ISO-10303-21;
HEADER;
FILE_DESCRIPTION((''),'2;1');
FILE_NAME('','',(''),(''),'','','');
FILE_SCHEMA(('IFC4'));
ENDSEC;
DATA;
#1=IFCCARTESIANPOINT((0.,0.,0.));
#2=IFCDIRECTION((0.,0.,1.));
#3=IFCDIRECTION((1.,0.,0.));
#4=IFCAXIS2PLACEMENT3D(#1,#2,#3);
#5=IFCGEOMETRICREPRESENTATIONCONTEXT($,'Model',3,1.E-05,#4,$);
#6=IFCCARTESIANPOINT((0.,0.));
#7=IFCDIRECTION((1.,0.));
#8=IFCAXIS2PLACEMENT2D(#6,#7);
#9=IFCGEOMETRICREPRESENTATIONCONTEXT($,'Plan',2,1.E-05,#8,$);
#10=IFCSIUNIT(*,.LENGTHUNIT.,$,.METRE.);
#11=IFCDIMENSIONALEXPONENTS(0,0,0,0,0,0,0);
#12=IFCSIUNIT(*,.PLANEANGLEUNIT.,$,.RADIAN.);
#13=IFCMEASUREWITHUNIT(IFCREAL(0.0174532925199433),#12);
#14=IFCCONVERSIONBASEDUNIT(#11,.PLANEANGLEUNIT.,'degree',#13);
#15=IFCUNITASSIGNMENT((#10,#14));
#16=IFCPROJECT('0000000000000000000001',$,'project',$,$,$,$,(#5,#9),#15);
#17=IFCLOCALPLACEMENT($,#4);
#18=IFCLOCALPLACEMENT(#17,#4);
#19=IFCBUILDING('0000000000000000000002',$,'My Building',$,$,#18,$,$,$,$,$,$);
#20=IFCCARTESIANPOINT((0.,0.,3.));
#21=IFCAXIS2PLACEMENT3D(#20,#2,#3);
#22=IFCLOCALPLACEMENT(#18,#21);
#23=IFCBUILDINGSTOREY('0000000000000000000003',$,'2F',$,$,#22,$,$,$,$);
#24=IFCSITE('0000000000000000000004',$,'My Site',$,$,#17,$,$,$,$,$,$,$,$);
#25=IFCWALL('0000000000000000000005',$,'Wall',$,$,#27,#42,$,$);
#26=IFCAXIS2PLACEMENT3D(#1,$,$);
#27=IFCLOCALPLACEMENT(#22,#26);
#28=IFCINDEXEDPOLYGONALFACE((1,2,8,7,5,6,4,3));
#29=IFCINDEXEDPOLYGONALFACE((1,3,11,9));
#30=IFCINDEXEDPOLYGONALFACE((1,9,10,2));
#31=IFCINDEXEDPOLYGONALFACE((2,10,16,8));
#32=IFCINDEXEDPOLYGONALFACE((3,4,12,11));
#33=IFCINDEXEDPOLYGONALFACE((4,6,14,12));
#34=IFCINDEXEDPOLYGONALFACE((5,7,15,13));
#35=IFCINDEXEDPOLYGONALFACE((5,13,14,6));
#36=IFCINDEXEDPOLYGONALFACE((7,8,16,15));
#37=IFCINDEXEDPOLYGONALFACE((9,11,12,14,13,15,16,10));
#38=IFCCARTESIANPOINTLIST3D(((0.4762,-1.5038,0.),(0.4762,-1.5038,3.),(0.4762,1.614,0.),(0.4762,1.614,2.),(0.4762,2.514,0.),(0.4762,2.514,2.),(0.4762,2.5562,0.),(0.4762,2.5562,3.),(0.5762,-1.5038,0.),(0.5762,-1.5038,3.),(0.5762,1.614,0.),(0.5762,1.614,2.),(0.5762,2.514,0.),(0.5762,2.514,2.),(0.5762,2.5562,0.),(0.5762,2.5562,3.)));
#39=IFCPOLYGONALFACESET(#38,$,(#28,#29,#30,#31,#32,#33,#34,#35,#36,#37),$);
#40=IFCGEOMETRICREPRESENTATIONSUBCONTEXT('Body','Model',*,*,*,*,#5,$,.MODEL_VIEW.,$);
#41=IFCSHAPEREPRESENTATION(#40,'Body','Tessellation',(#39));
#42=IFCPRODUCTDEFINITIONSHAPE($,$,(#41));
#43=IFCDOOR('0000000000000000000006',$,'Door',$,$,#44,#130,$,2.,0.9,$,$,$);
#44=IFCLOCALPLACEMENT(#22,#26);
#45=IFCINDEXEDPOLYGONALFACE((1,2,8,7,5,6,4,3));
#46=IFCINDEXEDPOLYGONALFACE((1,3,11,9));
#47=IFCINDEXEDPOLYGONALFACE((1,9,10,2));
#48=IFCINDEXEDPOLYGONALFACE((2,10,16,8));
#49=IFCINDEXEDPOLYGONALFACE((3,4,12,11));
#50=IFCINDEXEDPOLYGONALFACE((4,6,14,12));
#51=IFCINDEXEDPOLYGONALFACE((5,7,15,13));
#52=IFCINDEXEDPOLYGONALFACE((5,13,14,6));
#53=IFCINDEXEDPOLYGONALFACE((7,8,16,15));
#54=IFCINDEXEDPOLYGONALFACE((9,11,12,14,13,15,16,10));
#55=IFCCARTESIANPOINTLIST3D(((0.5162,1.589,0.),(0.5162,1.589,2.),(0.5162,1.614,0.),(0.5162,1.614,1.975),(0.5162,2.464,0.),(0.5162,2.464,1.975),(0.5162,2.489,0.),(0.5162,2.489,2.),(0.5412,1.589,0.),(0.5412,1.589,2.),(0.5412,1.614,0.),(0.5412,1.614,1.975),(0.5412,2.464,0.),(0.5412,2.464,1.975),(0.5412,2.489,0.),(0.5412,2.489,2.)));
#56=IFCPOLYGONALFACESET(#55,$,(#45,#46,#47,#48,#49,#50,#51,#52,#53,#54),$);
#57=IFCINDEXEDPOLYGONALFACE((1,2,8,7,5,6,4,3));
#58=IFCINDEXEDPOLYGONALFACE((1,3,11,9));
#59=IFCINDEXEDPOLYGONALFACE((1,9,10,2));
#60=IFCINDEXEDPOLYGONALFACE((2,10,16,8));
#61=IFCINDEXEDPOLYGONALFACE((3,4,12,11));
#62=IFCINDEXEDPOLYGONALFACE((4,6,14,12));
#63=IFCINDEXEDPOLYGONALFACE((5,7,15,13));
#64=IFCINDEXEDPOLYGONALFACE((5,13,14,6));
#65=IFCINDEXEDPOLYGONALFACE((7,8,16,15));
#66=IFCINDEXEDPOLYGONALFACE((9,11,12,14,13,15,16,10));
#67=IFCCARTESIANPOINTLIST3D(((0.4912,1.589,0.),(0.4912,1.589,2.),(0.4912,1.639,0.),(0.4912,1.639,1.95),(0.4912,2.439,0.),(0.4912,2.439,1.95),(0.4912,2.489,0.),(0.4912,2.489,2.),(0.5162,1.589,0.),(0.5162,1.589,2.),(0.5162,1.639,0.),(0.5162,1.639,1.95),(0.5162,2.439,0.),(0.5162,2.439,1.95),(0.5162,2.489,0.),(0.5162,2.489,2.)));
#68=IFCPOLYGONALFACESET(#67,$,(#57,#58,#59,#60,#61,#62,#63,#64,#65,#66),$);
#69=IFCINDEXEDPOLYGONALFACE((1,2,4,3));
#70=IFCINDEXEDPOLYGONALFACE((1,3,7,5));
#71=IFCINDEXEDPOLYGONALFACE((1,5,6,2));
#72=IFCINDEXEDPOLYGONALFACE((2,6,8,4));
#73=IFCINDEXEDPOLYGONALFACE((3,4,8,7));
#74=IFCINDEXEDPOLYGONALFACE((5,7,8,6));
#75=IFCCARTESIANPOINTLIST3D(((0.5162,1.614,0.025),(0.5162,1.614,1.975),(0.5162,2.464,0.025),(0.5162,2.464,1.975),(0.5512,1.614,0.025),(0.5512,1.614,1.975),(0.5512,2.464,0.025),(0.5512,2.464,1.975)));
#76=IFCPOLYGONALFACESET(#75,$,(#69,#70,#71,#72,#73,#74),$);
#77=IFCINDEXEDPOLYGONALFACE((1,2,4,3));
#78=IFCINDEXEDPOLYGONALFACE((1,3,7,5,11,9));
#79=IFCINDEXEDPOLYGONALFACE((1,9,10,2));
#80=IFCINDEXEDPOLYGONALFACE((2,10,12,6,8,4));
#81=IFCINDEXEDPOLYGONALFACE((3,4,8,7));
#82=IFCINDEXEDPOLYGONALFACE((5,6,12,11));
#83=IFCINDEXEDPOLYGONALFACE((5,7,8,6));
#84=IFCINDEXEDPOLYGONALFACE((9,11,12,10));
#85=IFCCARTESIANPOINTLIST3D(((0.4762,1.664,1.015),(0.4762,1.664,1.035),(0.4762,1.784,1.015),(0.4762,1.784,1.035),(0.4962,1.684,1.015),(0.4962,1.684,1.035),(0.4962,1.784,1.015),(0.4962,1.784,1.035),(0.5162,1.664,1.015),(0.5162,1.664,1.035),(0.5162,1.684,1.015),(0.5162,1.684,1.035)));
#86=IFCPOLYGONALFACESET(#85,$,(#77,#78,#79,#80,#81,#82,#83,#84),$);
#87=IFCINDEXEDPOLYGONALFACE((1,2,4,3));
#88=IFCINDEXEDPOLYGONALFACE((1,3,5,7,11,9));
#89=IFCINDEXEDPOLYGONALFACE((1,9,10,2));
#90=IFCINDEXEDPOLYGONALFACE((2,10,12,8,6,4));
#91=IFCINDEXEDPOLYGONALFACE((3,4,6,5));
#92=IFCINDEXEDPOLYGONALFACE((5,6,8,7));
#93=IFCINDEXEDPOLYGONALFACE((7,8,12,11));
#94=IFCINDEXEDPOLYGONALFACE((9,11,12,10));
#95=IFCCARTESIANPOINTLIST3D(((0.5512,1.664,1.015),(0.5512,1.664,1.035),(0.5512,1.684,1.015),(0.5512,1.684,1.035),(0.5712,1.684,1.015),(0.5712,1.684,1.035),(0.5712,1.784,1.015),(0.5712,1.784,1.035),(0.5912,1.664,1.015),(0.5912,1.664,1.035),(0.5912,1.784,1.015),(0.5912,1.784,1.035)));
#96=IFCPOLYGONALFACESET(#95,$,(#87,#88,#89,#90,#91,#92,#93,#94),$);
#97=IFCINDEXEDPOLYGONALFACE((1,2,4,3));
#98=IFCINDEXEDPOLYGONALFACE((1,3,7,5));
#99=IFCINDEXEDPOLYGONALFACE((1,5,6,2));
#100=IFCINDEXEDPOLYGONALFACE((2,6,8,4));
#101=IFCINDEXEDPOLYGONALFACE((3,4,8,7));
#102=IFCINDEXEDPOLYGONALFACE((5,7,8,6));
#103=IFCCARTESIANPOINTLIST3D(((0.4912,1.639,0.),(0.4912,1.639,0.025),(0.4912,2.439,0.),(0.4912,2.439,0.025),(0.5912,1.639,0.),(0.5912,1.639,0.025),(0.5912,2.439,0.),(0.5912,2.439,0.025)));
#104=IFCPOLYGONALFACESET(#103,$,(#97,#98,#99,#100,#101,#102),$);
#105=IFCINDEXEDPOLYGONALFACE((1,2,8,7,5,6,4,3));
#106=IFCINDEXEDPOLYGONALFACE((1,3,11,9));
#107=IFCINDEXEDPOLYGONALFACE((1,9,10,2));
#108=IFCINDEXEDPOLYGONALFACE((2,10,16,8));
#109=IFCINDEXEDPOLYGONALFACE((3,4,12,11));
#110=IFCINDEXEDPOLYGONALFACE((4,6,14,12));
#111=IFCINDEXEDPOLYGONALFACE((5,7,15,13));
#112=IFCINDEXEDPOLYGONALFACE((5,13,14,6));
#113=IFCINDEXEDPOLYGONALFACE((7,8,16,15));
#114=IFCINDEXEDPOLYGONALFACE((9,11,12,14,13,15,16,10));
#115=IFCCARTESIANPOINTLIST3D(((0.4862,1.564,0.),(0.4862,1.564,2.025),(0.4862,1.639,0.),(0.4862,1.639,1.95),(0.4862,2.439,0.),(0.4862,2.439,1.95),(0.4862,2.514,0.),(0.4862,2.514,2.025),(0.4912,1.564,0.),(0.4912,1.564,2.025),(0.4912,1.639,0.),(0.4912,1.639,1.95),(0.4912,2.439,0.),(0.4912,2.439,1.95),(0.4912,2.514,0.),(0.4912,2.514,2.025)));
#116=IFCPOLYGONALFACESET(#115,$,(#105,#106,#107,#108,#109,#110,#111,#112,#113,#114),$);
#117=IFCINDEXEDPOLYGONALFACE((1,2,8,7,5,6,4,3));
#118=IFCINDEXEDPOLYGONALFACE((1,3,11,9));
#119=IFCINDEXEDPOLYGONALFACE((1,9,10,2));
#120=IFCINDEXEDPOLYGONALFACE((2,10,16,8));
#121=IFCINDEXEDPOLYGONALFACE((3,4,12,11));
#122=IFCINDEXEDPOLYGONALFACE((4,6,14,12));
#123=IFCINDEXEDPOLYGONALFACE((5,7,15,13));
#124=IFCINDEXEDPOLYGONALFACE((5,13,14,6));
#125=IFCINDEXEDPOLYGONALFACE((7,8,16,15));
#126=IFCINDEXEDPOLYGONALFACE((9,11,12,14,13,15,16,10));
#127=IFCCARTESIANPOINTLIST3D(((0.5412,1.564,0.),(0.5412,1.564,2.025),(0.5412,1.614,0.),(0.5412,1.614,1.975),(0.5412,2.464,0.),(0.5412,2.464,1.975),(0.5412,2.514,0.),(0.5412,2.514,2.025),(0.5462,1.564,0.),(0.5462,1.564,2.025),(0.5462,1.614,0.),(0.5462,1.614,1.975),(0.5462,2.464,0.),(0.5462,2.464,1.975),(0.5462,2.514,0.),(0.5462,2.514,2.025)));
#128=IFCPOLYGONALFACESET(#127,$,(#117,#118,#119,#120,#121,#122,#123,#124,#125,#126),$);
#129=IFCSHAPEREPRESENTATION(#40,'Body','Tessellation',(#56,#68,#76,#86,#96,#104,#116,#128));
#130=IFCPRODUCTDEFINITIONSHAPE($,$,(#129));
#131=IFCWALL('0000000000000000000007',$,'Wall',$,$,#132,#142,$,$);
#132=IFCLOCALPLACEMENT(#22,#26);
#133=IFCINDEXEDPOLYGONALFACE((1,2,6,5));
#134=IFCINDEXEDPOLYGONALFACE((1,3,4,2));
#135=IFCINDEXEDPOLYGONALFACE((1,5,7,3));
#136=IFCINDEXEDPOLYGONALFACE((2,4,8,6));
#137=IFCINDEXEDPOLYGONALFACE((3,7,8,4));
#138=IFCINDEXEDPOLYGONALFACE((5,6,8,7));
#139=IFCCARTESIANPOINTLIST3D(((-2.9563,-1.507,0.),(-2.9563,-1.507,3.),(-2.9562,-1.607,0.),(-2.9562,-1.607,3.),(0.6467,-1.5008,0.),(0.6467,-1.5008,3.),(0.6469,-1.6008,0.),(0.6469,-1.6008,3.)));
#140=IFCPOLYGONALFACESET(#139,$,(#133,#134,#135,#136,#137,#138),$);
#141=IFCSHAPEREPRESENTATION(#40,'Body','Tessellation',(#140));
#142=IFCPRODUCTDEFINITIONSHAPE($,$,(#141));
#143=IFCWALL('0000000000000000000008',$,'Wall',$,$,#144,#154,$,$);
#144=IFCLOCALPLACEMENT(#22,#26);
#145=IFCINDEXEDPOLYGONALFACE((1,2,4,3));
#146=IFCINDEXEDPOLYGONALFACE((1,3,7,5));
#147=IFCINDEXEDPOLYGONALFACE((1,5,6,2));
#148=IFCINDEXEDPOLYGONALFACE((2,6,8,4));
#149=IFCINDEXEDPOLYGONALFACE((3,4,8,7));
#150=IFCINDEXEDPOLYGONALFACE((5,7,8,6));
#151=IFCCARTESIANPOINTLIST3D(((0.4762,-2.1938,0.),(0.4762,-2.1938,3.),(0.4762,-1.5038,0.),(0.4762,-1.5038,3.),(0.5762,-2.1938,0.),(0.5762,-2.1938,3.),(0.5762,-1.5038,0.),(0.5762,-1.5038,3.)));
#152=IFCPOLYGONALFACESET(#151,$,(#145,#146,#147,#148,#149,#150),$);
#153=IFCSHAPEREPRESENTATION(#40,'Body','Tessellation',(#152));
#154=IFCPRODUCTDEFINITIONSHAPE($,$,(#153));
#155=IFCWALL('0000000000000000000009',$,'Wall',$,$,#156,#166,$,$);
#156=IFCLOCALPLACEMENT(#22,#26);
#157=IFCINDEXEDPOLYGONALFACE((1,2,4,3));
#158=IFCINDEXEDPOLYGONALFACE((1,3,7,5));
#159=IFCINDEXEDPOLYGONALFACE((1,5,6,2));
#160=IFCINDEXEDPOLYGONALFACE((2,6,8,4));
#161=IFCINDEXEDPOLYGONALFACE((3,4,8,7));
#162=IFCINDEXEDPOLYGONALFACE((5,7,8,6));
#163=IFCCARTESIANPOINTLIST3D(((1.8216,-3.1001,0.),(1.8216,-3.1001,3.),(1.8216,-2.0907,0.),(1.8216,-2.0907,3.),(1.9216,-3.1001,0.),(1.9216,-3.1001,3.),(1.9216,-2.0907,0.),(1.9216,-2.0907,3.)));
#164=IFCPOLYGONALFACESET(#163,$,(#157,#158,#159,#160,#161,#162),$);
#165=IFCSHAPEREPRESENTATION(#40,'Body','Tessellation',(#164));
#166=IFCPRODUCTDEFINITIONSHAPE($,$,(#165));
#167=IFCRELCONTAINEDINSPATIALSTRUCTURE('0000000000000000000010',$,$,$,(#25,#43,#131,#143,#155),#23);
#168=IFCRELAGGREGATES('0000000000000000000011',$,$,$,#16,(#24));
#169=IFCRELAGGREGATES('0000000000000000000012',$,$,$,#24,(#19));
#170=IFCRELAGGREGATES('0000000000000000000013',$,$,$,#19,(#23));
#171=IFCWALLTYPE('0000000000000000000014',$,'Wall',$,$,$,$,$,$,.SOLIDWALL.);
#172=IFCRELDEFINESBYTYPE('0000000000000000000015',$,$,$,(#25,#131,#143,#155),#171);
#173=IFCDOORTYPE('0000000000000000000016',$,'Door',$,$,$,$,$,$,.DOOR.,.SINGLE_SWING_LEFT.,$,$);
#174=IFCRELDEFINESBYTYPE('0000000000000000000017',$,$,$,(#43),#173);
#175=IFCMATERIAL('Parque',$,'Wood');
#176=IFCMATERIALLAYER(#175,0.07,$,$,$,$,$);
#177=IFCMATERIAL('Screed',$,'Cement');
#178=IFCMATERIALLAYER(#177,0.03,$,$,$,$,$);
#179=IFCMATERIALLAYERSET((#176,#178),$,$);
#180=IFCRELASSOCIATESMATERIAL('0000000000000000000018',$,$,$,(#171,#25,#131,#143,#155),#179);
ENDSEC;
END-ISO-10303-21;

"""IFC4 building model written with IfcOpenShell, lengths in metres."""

from ifc_helpers import new_model, entity, si_unit, converted_unit, frame, origin_with_axes, origin_2d_with_axis, place, context, subcontext, project, spatial, line, indexed_curve, outline, extrude, shape, source, transform, mapped, material, layer, layer_set, layer_usage, type_object, type_shapes, element, fill, save


model = new_model("IFC4")

# Units and contexts
model_context = context("Model", 3, precision=1e-05, world=origin_with_axes())
plan_context = context("Plan", 2, precision=1e-05, world=origin_2d_with_axis())
body_context_1 = subcontext(model_context, "Body", "Model", "MODEL_VIEW")
body_context_2 = subcontext(plan_context, "Body", "Plan", "PLAN_VIEW")
ifc_project = project(units=[si_unit("LENGTHUNIT", "METRE"), converted_unit("PLANEANGLEUNIT", "degree", entity("IfcReal", 0.0174532925199433), si_unit("PLANEANGLEUNIT", "RADIAN"), dimensions=[0, 0, 0, 0, 0, 0, 0])], contexts=[model_context, plan_context])

# Site, building, storey
site_placement = place(None, origin_with_axes())
site = spatial("IfcSite", under=ifc_project, at=site_placement, Name="My Site")
building_placement = place(site_placement, origin_with_axes())
building = spatial("IfcBuilding", under=site, at=building_placement, Name="My Building")
storey_placement = place(building_placement, frame((0.0, 0.0, 3.0), z_axis=(0.0, 0.0, 1.0), x_axis=(1.0, 0.0, 0.0)))
storey = spatial("IfcBuildingStorey", under=building, at=storey_placement, Name="2F")

# Shared definitions
ifc_material_1 = material(Name="Parque", Category="Wood")
ifc_layer_1 = layer(ifc_material_1, 0.07)
ifc_material_2 = material(Name="Screed", Category="Cement")
ifc_layer_2 = layer(ifc_material_2, 0.03)
ifc_layer_set_1 = layer_set([ifc_layer_1, ifc_layer_2])
wall_type = type_object("IfcWallType", Name="Wall", PredefinedType="SOLIDWALL", material=ifc_layer_set_1)

# Wall, opening, door
ifc_layer_usage_1 = layer_usage(ifc_layer_set_1, "AXIS2", "POSITIVE", 0.0)
wall_1_placement = place(storey_placement, frame((0.5762, -1.5038, 0.0), z_axis=(0.0, 0.0, 1.0), x_axis=(0.0, 1.0, 0.0)))
wall_1 = element("IfcWall", 1, at=wall_1_placement, inside=storey, type_object=wall_type, material=ifc_layer_usage_1, Name="Wall", context=body_context_1, shape_type="SweptSolid", body=[
    extrude(outline(indexed_curve([(0.0, 0.0), (0.0, 0.1), (4.06, 0.1), (4.06, 0.0)], segments=[line(1, 2, 3, 4, 1)])), origin_with_axes(), (0.0, 0.0, 1.0), 3.0),
])
shared_shape_1 = source(origin_with_axes(), body_context_1, "Body", "SweptSolid", [
    extrude(outline(indexed_curve([(0.0, 0.0), (0.9, 0.0), (0.9, 2.0), (0.0, 2.0)], segments=[line(1, 2, 3, 4, 1)])), frame((0.0, -0.6, 0.0), z_axis=(0.0, -1.0, 0.0), x_axis=(1.0, 0.0, 0.0)), (0.0, 0.0, -1.0), 1.2),
])
opening_1_placement = place(wall_1_placement, frame((3.1178, 0.0, 0.0), z_axis=(0.0, 0.0, 1.0), x_axis=(1.0, 0.0, 0.0)))
opening_1 = element("IfcOpeningElement", 2, at=opening_1_placement, cuts=wall_1, PredefinedType="OPENING", context=body_context_1, shape_type="MappedRepresentation", body=[
    mapped(shared_shape_1, transform((0.0, 0.0, 0.0), x_axis=(1.0, 0.0, 0.0), y_axis=(0.0, 1.0, 0.0), z_axis=(0.0, 0.0, 1.0), scale=1.0)),
])
door_type = type_object("IfcDoorType", Name="Door", OperationType="SINGLE_SWING_LEFT", PredefinedType="DOOR")
shared_shape_2 = source(origin_with_axes(), body_context_1, "Body", "SweptSolid", [
    extrude(outline(indexed_curve([(0.0, 0.0), (0.0, 2.0), (0.9, 2.0), (0.9, 0.0), (0.875, 0.0), (0.875, 1.975), (0.025, 1.975), (0.025, 0.0)], segments=[line(1, 2, 3, 4, 5, 6, 7, 8, 1)])), frame((0.0, 0.025, 0.0), z_axis=(0.0, -1.0, 0.0), x_axis=(1.0, 0.0, 0.0)), (0.0, 0.0, -1.0), 0.025),
    extrude(outline(indexed_curve([(0.0, 0.0), (0.0, 2.0), (0.9, 2.0), (0.9, 0.0), (0.85, 0.0), (0.85, 1.95), (0.05, 1.95), (0.05, 0.0)], segments=[line(1, 2, 3, 4, 5, 6, 7, 8, 1)])), frame((0.0, 0.0, 0.0), z_axis=(0.0, -1.0, 0.0), x_axis=(1.0, 0.0, 0.0)), (0.0, 0.0, -1.0), 0.025),
    extrude(outline(indexed_curve([(0.0, 0.0), (0.85, 0.0), (0.85, 0.035), (0.0, 0.035)], segments=[line(1, 2, 3, 4, 1)])), frame((0.025, 0.025, 0.025), z_axis=(0.0, 0.0, 1.0), x_axis=(1.0, 0.0, 0.0)), (0.0, 0.0, 1.0), 1.95),
    extrude(outline(indexed_curve([(0.0, 0.0), (0.0, -0.04), (-0.12, -0.04), (-0.12, -0.02), (-0.02, -0.02), (-0.02, 0.0)], segments=[line(1, 2, 3, 4, 5, 6, 1)])), frame((0.825, 0.025, 1.015), z_axis=(0.0, 0.0, 1.0), x_axis=(1.0, 0.0, 0.0)), (0.0, 0.0, 1.0), 0.02),
    extrude(outline(indexed_curve([(0.0, 0.0), (0.0, 0.04), (-0.12, 0.04), (-0.12, 0.02), (-0.02, 0.02), (-0.02, 0.0)], segments=[line(1, 2, 3, 4, 5, 6, 1)])), frame((0.825, 0.06, 1.015), z_axis=(0.0, 0.0, 1.0), x_axis=(1.0, 0.0, 0.0)), (0.0, 0.0, 1.0), 0.02),
    extrude(outline(indexed_curve([(0.0, 0.0), (0.8, 0.0), (0.8, 0.1), (0.0, 0.1)], segments=[line(1, 2, 3, 4, 1)])), frame((0.05, 0.0, 0.0), z_axis=(0.0, 0.0, 1.0), x_axis=(1.0, 0.0, 0.0)), (0.0, 0.0, 1.0), 0.025),
    extrude(outline(indexed_curve([(0.0, 0.0), (0.0, 2.025), (0.95, 2.025), (0.95, 0.0), (0.875, 0.0), (0.875, 1.95), (0.075, 1.95), (0.075, 0.0)], segments=[line(1, 2, 3, 4, 5, 6, 7, 8, 1)])), frame((-0.025, -0.005, 0.0), z_axis=(0.0, -1.0, 0.0), x_axis=(1.0, 0.0, 0.0)), (0.0, 0.0, -1.0), 0.005),
    extrude(outline(indexed_curve([(0.0, 0.0), (0.0, 2.025), (0.95, 2.025), (0.95, 0.0), (0.9, 0.0), (0.9, 1.975), (0.05, 1.975), (0.05, 0.0)], segments=[line(1, 2, 3, 4, 5, 6, 7, 8, 1)])), frame((-0.025, 0.05, 0.0), z_axis=(0.0, -1.0, 0.0), x_axis=(1.0, 0.0, 0.0)), (0.0, 0.0, -1.0), 0.005),
])
shared_shape_3 = source(origin_with_axes(), body_context_2, "Body", "Curve2D", [
    entity("IfcIndexedPolyCurve", entity("IfcCartesianPointList2D", [[0.0, 0.0], [0.0, 0.05], [0.025, 0.05], [0.025, 0.025], [0.05, 0.025], [0.05, 0.0]]), [entity("IfcLineIndex", [1, 2, 3, 4, 5, 6, 1])]),
    entity("IfcIndexedPolyCurve", entity("IfcCartesianPointList2D", [[0.9, 0.0], [0.9, 0.05], [0.875, 0.05], [0.875, 0.025], [0.85, 0.025], [0.85, 0.0]]), [entity("IfcLineIndex", [1, 2, 3, 4, 5, 6, 1])]),
    entity("IfcTrimmedCurve", entity("IfcEllipse", entity("IfcAxis2Placement2D", entity("IfcCartesianPoint", [0.06, 0.05]), entity("IfcDirection", [1.0, 0.0])), 0.815, 0.85), [entity("IfcCartesianPoint", [0.875, 0.05])], [entity("IfcCartesianPoint", [0.06, 0.9])], True, "CARTESIAN"),
    entity("IfcIndexedPolyCurve", entity("IfcCartesianPointList2D", [[0.025, 0.05], [0.06, 0.05], [0.06, 0.9], [0.025, 0.9]]), [entity("IfcLineIndex", [1, 2, 3, 4, 1])]),
])
type_shapes(door_type, [shared_shape_2, shared_shape_3])
door_1_placement = place(opening_1_placement, frame((0.875, 0.085, 0.0), z_axis=(0.0, 0.0, 1.0), x_axis=(-1.0, -0.000001, 0.0)))
door_1 = element("IfcDoor", 3, at=door_1_placement, inside=storey, type_object=door_type, Name="Door", OverallHeight=2.0, OverallWidth=0.9, shapes=[
    shape(body_context_1, "Body", "MappedRepresentation", [mapped(shared_shape_2, transform((0.0, 0.0, 0.0), x_axis=(1.0, 0.0, 0.0), y_axis=(0.0, 1.0, 0.0), z_axis=(0.0, 0.0, 1.0), scale=1.0))]),
    shape(body_context_2, "Body", "MappedRepresentation", [mapped(shared_shape_3, transform((0.0, 0.0, 0.0), x_axis=(1.0, 0.0, 0.0), y_axis=(0.0, 1.0, 0.0), z_axis=(0.0, 0.0, 1.0), scale=1.0))]),
])
fill(opening_1, door_1)

# Walls
ifc_layer_usage_2 = layer_usage(ifc_layer_set_1, "AXIS2", "POSITIVE", 0.0)
wall_2_placement = place(storey_placement, frame((-2.9562, -1.607, 0.0), z_axis=(0.0, 0.0, 1.0), x_axis=(0.999999, 0.001712, 0.0)))
element("IfcWall", 4, at=wall_2_placement, inside=storey, type_object=wall_type, material=ifc_layer_usage_2, Name="Wall", context=body_context_1, shape_type="SweptSolid", body=[
    extrude(outline(indexed_curve([(0.0, 0.0), (0.0, 0.1), (3.6031, 0.1), (3.6031, 0.0)], segments=[line(1, 2, 3, 4, 1)])), origin_with_axes(), (0.0, 0.0, 1.0), 3.0),
])
ifc_layer_usage_3 = layer_usage(ifc_layer_set_1, "AXIS2", "POSITIVE", 0.0)
wall_3_placement = place(storey_placement, frame((0.4762, -1.5038, 0.0), z_axis=(0.0, 0.0, 1.0), x_axis=(0.0, -1.0, 0.0)))
element("IfcWall", 5, at=wall_3_placement, inside=storey, type_object=wall_type, material=ifc_layer_usage_3, Name="Wall", context=body_context_1, shape_type="SweptSolid", body=[
    extrude(outline(indexed_curve([(0.0, 0.0), (0.0, 0.1), (0.69, 0.1), (0.69, 0.0)], segments=[line(1, 2, 3, 4, 1)])), origin_with_axes(), (0.0, 0.0, 1.0), 3.0),
])
ifc_layer_usage_4 = layer_usage(ifc_layer_set_1, "AXIS2", "POSITIVE", 0.0)
wall_4_placement = place(storey_placement, frame((1.9216, -3.1001, 0.0), z_axis=(0.0, 0.0, 1.0), x_axis=(0.000002, 1.0, 0.0)))
element("IfcWall", 6, at=wall_4_placement, inside=storey, type_object=wall_type, material=ifc_layer_usage_4, Name="Wall", context=body_context_1, shape_type="SweptSolid", body=[
    extrude(outline(indexed_curve([(0.0, 0.0), (0.0, 0.1), (1.0094, 0.1), (1.0094, 0.0)], segments=[line(1, 2, 3, 4, 1)])), origin_with_axes(), (0.0, 0.0, 1.0), 3.0),
])

save(model, "model.ifc")
